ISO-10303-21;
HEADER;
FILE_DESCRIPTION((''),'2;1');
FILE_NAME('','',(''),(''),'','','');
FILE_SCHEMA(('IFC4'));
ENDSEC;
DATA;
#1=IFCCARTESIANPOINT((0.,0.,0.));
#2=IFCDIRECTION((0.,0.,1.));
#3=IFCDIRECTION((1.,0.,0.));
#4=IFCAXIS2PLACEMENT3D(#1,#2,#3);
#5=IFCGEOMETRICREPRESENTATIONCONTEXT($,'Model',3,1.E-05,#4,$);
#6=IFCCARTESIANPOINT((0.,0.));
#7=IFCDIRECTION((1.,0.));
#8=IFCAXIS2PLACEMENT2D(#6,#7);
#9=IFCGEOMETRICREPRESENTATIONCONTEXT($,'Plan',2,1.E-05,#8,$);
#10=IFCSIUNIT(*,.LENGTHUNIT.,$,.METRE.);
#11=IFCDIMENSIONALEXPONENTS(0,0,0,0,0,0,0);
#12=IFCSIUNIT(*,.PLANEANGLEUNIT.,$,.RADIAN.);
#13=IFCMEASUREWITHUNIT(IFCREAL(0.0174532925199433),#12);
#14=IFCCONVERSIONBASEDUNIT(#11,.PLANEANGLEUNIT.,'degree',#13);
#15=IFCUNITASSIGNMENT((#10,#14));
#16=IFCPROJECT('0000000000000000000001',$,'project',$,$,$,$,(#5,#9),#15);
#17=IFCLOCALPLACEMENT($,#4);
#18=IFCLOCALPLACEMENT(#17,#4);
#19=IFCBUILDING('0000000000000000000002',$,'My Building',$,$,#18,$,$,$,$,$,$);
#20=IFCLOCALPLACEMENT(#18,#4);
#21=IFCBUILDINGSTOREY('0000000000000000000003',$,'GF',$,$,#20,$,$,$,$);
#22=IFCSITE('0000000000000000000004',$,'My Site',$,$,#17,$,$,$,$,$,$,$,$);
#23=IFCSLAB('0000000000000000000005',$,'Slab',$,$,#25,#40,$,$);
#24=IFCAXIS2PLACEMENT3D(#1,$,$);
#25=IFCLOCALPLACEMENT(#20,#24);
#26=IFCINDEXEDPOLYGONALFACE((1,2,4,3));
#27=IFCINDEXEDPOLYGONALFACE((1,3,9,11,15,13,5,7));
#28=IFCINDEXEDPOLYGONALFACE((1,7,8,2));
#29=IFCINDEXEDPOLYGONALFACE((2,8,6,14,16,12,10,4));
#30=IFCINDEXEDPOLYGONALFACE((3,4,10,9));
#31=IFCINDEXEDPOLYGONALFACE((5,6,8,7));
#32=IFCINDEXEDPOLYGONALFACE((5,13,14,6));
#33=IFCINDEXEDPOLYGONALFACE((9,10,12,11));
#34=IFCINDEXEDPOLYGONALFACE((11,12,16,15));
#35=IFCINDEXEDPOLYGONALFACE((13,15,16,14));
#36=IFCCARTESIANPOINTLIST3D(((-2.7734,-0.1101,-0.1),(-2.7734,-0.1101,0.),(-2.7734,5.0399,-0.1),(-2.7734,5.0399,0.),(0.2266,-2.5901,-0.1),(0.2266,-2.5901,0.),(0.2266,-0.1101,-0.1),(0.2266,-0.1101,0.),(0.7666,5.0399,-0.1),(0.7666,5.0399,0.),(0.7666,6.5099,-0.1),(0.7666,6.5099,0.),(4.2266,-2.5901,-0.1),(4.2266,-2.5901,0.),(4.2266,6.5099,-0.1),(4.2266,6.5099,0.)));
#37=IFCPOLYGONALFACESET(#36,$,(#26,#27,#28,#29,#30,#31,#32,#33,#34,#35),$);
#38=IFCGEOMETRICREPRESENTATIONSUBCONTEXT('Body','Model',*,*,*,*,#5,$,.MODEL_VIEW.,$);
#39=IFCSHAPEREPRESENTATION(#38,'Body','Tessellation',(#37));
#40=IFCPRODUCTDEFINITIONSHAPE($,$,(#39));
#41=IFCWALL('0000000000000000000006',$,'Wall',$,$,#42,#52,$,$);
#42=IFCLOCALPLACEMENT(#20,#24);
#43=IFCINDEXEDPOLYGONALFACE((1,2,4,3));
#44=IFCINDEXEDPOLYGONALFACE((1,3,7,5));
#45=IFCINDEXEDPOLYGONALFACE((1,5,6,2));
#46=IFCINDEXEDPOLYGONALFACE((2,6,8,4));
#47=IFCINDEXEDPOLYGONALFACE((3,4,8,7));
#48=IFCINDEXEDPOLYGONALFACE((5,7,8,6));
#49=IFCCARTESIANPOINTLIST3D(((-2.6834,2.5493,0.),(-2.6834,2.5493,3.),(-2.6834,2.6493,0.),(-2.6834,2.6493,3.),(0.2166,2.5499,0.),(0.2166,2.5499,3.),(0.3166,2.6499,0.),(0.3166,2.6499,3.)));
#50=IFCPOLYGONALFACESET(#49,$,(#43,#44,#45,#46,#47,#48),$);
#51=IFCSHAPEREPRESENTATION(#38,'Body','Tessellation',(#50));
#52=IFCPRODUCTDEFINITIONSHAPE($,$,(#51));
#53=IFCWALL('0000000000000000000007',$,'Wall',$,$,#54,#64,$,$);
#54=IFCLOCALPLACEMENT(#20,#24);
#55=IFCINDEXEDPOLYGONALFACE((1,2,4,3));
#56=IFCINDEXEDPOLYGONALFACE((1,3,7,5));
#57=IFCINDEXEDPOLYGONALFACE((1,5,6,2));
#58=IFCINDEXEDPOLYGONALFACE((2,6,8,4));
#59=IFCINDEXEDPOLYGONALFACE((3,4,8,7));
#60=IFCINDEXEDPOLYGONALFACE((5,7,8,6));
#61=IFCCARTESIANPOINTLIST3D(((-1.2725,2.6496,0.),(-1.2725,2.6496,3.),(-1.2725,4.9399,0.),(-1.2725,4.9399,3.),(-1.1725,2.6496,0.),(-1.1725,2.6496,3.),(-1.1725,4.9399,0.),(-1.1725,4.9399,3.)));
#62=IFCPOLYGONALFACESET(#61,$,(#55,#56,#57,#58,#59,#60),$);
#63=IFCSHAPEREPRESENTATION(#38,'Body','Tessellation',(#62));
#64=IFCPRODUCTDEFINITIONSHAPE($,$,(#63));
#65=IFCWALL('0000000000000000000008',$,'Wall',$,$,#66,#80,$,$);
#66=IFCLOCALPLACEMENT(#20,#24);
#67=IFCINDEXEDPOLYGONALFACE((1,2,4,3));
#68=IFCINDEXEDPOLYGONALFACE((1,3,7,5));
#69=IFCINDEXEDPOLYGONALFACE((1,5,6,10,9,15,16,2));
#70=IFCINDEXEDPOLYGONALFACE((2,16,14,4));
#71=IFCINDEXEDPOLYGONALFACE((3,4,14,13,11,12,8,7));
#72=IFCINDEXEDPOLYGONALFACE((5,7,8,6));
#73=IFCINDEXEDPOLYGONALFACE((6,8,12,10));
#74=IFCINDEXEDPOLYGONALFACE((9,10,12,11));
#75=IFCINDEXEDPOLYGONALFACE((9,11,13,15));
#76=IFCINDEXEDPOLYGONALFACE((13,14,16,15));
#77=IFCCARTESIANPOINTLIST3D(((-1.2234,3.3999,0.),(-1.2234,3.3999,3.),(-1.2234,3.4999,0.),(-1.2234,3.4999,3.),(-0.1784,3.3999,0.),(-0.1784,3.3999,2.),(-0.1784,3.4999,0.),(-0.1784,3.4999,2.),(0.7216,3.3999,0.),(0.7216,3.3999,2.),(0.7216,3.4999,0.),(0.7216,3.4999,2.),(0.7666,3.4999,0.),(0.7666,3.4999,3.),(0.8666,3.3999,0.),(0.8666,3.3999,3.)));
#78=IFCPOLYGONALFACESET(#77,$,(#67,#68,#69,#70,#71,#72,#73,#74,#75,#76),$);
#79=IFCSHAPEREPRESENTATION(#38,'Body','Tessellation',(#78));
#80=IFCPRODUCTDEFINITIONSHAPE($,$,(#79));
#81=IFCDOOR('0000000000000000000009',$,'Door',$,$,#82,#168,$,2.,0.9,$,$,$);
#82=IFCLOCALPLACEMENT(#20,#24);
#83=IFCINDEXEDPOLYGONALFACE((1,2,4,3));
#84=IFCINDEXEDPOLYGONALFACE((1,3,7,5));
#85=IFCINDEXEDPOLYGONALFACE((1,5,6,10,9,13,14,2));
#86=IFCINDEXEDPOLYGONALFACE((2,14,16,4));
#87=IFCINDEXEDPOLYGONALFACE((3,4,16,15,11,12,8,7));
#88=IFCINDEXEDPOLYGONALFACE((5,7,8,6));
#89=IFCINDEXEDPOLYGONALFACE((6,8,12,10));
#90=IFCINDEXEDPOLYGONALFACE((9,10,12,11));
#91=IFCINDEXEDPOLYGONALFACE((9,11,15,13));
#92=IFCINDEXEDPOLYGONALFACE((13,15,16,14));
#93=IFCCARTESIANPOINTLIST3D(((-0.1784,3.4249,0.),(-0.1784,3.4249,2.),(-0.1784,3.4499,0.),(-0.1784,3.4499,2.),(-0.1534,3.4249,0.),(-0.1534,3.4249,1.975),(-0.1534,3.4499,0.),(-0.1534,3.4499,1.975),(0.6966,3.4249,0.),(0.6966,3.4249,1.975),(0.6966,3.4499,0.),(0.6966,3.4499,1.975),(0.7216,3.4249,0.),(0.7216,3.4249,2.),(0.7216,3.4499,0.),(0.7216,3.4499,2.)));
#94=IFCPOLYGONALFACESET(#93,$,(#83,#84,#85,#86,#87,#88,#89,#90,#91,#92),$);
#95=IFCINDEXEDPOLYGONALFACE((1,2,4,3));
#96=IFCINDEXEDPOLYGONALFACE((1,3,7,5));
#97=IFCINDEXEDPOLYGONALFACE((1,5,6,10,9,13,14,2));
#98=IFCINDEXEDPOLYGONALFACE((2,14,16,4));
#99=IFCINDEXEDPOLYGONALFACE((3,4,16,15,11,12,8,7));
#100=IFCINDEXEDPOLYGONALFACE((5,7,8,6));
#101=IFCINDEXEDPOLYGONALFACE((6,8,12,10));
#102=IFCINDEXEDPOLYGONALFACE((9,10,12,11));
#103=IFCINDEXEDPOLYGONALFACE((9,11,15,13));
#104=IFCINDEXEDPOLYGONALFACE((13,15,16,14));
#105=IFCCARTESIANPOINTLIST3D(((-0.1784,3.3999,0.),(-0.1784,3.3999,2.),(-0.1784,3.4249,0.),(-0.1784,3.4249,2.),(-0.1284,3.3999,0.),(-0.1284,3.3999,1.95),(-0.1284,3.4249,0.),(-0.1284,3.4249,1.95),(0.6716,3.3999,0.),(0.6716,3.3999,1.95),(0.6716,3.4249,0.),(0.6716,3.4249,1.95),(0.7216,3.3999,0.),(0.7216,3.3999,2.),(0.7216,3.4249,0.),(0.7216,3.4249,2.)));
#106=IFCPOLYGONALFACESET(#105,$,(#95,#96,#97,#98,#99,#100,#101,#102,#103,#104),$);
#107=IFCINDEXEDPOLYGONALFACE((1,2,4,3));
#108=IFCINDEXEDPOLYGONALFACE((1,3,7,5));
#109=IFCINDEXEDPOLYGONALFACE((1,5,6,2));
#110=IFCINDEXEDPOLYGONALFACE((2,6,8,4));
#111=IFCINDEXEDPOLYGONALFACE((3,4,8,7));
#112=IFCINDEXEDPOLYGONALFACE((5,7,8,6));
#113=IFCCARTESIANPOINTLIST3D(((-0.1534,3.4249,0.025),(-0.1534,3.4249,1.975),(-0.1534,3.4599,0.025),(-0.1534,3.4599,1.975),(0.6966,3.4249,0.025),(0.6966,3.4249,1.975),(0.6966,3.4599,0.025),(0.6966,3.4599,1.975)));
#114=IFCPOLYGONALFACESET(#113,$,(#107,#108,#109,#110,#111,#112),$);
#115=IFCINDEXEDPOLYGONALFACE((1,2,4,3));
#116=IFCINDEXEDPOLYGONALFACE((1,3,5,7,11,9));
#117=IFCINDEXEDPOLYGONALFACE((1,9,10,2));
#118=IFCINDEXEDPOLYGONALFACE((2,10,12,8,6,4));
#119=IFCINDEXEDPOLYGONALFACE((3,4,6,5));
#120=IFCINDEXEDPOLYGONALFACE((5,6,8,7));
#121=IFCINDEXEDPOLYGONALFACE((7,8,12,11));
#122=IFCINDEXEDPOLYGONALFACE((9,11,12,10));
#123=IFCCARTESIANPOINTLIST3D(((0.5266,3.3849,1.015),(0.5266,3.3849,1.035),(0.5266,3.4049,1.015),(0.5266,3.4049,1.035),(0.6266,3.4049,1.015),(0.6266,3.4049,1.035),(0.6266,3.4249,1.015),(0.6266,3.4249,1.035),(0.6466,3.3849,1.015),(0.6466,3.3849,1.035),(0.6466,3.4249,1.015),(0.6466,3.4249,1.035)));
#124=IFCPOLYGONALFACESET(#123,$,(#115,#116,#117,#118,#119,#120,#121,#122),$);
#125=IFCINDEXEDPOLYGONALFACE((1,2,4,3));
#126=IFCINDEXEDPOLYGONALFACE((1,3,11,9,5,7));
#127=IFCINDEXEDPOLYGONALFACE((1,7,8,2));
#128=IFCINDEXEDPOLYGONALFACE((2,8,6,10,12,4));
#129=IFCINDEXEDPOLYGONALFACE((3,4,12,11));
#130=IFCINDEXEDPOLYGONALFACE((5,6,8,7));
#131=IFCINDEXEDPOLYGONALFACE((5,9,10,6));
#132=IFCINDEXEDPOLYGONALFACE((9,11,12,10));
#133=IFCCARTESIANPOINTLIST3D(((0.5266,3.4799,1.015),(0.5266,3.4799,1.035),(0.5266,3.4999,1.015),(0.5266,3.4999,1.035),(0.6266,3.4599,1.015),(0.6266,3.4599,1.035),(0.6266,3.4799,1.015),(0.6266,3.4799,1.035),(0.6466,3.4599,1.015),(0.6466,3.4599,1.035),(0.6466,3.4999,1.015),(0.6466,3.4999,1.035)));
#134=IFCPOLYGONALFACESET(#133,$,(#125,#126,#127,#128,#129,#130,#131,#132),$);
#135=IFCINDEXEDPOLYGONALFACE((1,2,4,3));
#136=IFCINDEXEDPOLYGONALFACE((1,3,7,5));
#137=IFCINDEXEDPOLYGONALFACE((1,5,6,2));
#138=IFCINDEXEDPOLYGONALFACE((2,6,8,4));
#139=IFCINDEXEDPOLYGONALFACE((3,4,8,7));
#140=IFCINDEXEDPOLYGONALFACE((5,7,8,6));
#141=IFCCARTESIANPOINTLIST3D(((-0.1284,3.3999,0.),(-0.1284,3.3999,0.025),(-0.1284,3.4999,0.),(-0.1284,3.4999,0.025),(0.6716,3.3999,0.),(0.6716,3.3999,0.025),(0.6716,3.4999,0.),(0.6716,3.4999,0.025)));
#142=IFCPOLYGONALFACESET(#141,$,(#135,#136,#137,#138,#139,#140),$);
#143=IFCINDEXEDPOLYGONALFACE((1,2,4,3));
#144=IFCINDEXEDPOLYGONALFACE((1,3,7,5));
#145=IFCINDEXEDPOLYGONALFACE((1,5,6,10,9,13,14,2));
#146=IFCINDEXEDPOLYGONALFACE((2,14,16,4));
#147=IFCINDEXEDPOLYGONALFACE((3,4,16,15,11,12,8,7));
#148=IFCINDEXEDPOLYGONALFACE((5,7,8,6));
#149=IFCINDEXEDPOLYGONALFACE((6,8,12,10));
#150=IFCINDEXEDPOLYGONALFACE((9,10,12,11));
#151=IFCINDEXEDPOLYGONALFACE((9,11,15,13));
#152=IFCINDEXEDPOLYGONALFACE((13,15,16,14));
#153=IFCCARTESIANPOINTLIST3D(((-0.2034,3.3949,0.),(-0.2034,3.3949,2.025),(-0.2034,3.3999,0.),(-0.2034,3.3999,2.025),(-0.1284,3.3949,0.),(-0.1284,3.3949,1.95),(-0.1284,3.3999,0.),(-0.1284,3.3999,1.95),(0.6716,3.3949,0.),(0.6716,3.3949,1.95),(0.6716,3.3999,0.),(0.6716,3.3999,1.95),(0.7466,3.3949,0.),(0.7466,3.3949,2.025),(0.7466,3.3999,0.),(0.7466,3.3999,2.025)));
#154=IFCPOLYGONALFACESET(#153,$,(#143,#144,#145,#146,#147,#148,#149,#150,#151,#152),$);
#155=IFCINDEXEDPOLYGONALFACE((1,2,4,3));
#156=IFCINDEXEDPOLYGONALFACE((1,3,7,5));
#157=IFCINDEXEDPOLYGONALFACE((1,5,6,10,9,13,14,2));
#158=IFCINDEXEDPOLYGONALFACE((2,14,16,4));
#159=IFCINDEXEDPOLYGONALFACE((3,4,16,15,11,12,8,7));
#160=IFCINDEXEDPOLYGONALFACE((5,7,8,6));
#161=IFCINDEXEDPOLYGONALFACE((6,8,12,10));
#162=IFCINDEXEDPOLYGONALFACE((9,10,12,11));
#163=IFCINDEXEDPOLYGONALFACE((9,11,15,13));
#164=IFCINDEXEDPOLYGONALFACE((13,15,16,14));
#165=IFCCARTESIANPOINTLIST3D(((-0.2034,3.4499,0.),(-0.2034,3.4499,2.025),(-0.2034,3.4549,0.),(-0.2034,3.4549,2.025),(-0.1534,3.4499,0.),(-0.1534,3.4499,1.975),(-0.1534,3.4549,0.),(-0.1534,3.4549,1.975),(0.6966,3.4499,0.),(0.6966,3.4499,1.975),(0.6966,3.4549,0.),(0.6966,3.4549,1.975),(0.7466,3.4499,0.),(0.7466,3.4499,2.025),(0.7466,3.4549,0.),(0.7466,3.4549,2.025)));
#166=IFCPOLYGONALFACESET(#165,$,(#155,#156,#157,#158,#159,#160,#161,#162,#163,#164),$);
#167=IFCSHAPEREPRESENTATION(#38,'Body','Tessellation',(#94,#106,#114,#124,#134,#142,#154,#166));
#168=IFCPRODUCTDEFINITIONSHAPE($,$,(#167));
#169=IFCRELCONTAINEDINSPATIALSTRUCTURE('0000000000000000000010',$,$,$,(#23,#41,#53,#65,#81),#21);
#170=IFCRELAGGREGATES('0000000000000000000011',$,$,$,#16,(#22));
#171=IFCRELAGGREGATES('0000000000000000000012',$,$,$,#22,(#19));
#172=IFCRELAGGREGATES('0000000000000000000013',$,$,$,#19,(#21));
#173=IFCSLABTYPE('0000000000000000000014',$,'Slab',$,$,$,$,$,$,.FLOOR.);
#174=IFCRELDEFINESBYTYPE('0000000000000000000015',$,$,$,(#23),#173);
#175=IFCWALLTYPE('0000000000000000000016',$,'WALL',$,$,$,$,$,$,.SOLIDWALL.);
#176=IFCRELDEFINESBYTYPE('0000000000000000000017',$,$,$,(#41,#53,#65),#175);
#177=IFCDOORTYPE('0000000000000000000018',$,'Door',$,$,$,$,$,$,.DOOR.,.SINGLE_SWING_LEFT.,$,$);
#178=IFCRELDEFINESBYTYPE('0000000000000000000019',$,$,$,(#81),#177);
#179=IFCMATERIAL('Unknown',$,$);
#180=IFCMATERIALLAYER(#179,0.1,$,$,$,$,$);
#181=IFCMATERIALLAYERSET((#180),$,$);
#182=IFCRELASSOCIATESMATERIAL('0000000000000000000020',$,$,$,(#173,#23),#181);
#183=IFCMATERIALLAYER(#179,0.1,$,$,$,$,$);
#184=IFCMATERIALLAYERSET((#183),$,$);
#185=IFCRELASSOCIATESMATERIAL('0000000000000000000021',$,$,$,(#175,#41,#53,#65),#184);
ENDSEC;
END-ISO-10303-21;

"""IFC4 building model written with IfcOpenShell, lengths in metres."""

from ifc_helpers import new_model, entity, si_unit, converted_unit, frame, origin_with_axes, origin_2d_with_axis, place, context, subcontext, project, spatial, line, indexed_curve, outline, extrude, shape, source, transform, mapped, material, layer, layer_set, layer_usage, type_object, type_shapes, element, fill, save


model = new_model("IFC4")

# Units and contexts
model_context = context("Model", 3, precision=1e-05, world=origin_with_axes())
plan_context = context("Plan", 2, precision=1e-05, world=origin_2d_with_axis())
body_context_1 = subcontext(model_context, "Body", "Model", "MODEL_VIEW")
body_context_2 = subcontext(plan_context, "Body", "Plan", "PLAN_VIEW")
ifc_project = project(units=[si_unit("LENGTHUNIT", "METRE"), converted_unit("PLANEANGLEUNIT", "degree", entity("IfcReal", 0.0174532925199433), si_unit("PLANEANGLEUNIT", "RADIAN"), dimensions=[0, 0, 0, 0, 0, 0, 0])], contexts=[model_context, plan_context])

# Site, building, storey
site_placement = place(None, origin_with_axes())
site = spatial("IfcSite", under=ifc_project, at=site_placement, Name="My Site")
building_placement = place(site_placement, origin_with_axes())
building = spatial("IfcBuilding", under=site, at=building_placement, Name="My Building")
storey_placement = place(building_placement, origin_with_axes())
storey = spatial("IfcBuildingStorey", under=building, at=storey_placement, Name="GF")

# Slab
ifc_material = material(Name="Unknown")
ifc_layer_1 = layer(ifc_material, 0.1)
ifc_layer_set_1 = layer_set([ifc_layer_1])
ifc_layer_usage_1 = layer_usage(ifc_layer_set_1, "AXIS3", "POSITIVE", -0.1)
slab_type = type_object("IfcSlabType", Name="Slab", PredefinedType="FLOOR", material=ifc_layer_set_1)
slab_placement = place(storey_placement, frame((4.2266, -2.5901, 0.0), z_axis=(0.0, 0.0, 1.0), x_axis=(1.0, 0.0, 0.0)))
element("IfcSlab", 1, at=slab_placement, inside=storey, type_object=slab_type, material=ifc_layer_usage_1, Name="Slab", context=body_context_1, shape_type="SweptSolid", body=[
    extrude(outline(indexed_curve([(0.0, 0.0), (0.0, 9.1), (-3.46, 9.1), (-3.46, 7.63), (-7.0, 7.63), (-7.0, 2.48), (-4.0, 2.48), (-4.0, 0.0), (0.0, 0.0)])), frame((0.0, 0.0, -0.1), z_axis=(0.0, 0.0, 1.0), x_axis=(1.0, 0.0, 0.0)), (0.0, 0.0, 1.0), 0.1),
])

# Walls
ifc_layer_2 = layer(ifc_material, 0.1)
ifc_layer_set_2 = layer_set([ifc_layer_2])
ifc_layer_usage_2 = layer_usage(ifc_layer_set_2, "AXIS2", "POSITIVE", 0.0)
wall_type_1 = type_object("IfcWallType", Name="WALL", PredefinedType="SOLIDWALL", material=ifc_layer_set_2)
wall_1_placement = place(storey_placement, frame((0.3166, 2.6499, 0.0), z_axis=(0.0, 0.0, 1.0), x_axis=(-1.0, -0.0002, 0.0)))
element("IfcWall", 2, at=wall_1_placement, inside=storey, type_object=wall_type_1, material=ifc_layer_usage_2, Name="Wall", context=body_context_1, shape_type="SweptSolid", body=[
    extrude(outline(indexed_curve([(0.0, 0.0), (0.1, 0.1), (3.0, 0.1), (3.0, 0.0)], segments=[line(1, 2, 3, 4, 1)])), origin_with_axes(), (0.0, 0.0, 1.0), 3.0),
])
ifc_layer_usage_3 = layer_usage(ifc_layer_set_2, "AXIS2", "POSITIVE", 0.0)
wall_2_placement = place(storey_placement, frame((-1.2725, 4.9399, 0.0), z_axis=(0.0, 0.0, 1.0), x_axis=(0.000001, -1.0, 0.0)))
element("IfcWall", 3, at=wall_2_placement, inside=storey, type_object=wall_type_1, material=ifc_layer_usage_3, Name="Wall", context=body_context_1, shape_type="SweptSolid", body=[
    extrude(outline(indexed_curve([(0.0, 0.0), (0.0, 0.1), (2.2903, 0.1), (2.2903, 0.0)], segments=[line(1, 2, 3, 4, 1)])), origin_with_axes(), (0.0, 0.0, 1.0), 3.0),
])

# Wall, opening, door
ifc_layer_usage_4 = layer_usage(ifc_layer_set_2, "AXIS2", "POSITIVE", 0.0)
wall_3_placement = place(storey_placement, frame((-1.2234, 3.3999, 0.0), z_axis=(0.0, 0.0, 1.0), x_axis=(1.0, 0.0, 0.0)))
wall_3 = element("IfcWall", 4, at=wall_3_placement, inside=storey, type_object=wall_type_1, material=ifc_layer_usage_4, Name="Wall", context=body_context_1, shape_type="SweptSolid", body=[
    extrude(outline(indexed_curve([(0.0, 0.0), (0.0, 0.1), (1.99, 0.1), (2.09, 0.0)], segments=[line(1, 2, 3, 4, 1)])), origin_with_axes(), (0.0, 0.0, 1.0), 3.0),
])
shared_shape_1 = source(origin_with_axes(), body_context_1, "Body", "SweptSolid", [
    extrude(outline(indexed_curve([(0.0, 0.0), (0.9, 0.0), (0.9, 2.0), (0.0, 2.0)], segments=[line(1, 2, 3, 4, 1)])), frame((0.0, -0.6, 0.0), z_axis=(0.0, -1.0, 0.0), x_axis=(1.0, 0.0, 0.0)), (0.0, 0.0, -1.0), 1.2),
])
opening_1_placement = place(wall_3_placement, frame((1.045, 0.0, 0.0), z_axis=(0.0, 0.0, 1.0), x_axis=(1.0, 0.0, 0.0)))
opening_1 = element("IfcOpeningElement", 5, at=opening_1_placement, cuts=wall_3, PredefinedType="OPENING", context=body_context_1, shape_type="MappedRepresentation", body=[
    mapped(shared_shape_1, transform((0.0, 0.0, 0.0), x_axis=(1.0, 0.0, 0.0), y_axis=(0.0, 1.0, 0.0), z_axis=(0.0, 0.0, 1.0), scale=1.0)),
])
door_type = type_object("IfcDoorType", Name="Door", OperationType="SINGLE_SWING_LEFT", PredefinedType="DOOR")
shared_shape_2 = source(origin_with_axes(), body_context_1, "Body", "SweptSolid", [
    extrude(outline(indexed_curve([(0.0, 0.0), (0.0, 2.0), (0.9, 2.0), (0.9, 0.0), (0.875, 0.0), (0.875, 1.975), (0.025, 1.975), (0.025, 0.0)], segments=[line(1, 2, 3, 4, 5, 6, 7, 8, 1)])), frame((0.0, 0.025, 0.0), z_axis=(0.0, -1.0, 0.0), x_axis=(1.0, 0.0, 0.0)), (0.0, 0.0, -1.0), 0.025),
    extrude(outline(indexed_curve([(0.0, 0.0), (0.0, 2.0), (0.9, 2.0), (0.9, 0.0), (0.85, 0.0), (0.85, 1.95), (0.05, 1.95), (0.05, 0.0)], segments=[line(1, 2, 3, 4, 5, 6, 7, 8, 1)])), frame((0.0, 0.0, 0.0), z_axis=(0.0, -1.0, 0.0), x_axis=(1.0, 0.0, 0.0)), (0.0, 0.0, -1.0), 0.025),
    extrude(outline(indexed_curve([(0.0, 0.0), (0.85, 0.0), (0.85, 0.035), (0.0, 0.035)], segments=[line(1, 2, 3, 4, 1)])), frame((0.025, 0.025, 0.025), z_axis=(0.0, 0.0, 1.0), x_axis=(1.0, 0.0, 0.0)), (0.0, 0.0, 1.0), 1.95),
    extrude(outline(indexed_curve([(0.0, 0.0), (0.0, -0.04), (-0.12, -0.04), (-0.12, -0.02), (-0.02, -0.02), (-0.02, 0.0)], segments=[line(1, 2, 3, 4, 5, 6, 1)])), frame((0.825, 0.025, 1.015), z_axis=(0.0, 0.0, 1.0), x_axis=(1.0, 0.0, 0.0)), (0.0, 0.0, 1.0), 0.02),
    extrude(outline(indexed_curve([(0.0, 0.0), (0.0, 0.04), (-0.12, 0.04), (-0.12, 0.02), (-0.02, 0.02), (-0.02, 0.0)], segments=[line(1, 2, 3, 4, 5, 6, 1)])), frame((0.825, 0.06, 1.015), z_axis=(0.0, 0.0, 1.0), x_axis=(1.0, 0.0, 0.0)), (0.0, 0.0, 1.0), 0.02),
    extrude(outline(indexed_curve([(0.0, 0.0), (0.8, 0.0), (0.8, 0.1), (0.0, 0.1)], segments=[line(1, 2, 3, 4, 1)])), frame((0.05, 0.0, 0.0), z_axis=(0.0, 0.0, 1.0), x_axis=(1.0, 0.0, 0.0)), (0.0, 0.0, 1.0), 0.025),
    extrude(outline(indexed_curve([(0.0, 0.0), (0.0, 2.025), (0.95, 2.025), (0.95, 0.0), (0.875, 0.0), (0.875, 1.95), (0.075, 1.95), (0.075, 0.0)], segments=[line(1, 2, 3, 4, 5, 6, 7, 8, 1)])), frame((-0.025, -0.005, 0.0), z_axis=(0.0, -1.0, 0.0), x_axis=(1.0, 0.0, 0.0)), (0.0, 0.0, -1.0), 0.005),
    extrude(outline(indexed_curve([(0.0, 0.0), (0.0, 2.025), (0.95, 2.025), (0.95, 0.0), (0.9, 0.0), (0.9, 1.975), (0.05, 1.975), (0.05, 0.0)], segments=[line(1, 2, 3, 4, 5, 6, 7, 8, 1)])), frame((-0.025, 0.05, 0.0), z_axis=(0.0, -1.0, 0.0), x_axis=(1.0, 0.0, 0.0)), (0.0, 0.0, -1.0), 0.005),
])
shared_shape_3 = source(origin_with_axes(), body_context_2, "Body", "Curve2D", [
    entity("IfcIndexedPolyCurve", entity("IfcCartesianPointList2D", [[0.0, 0.0], [0.0, 0.05], [0.025, 0.05], [0.025, 0.025], [0.05, 0.025], [0.05, 0.0]]), [entity("IfcLineIndex", [1, 2, 3, 4, 5, 6, 1])]),
    entity("IfcIndexedPolyCurve", entity("IfcCartesianPointList2D", [[0.9, 0.0], [0.9, 0.05], [0.875, 0.05], [0.875, 0.025], [0.85, 0.025], [0.85, 0.0]]), [entity("IfcLineIndex", [1, 2, 3, 4, 5, 6, 1])]),
    entity("IfcTrimmedCurve", entity("IfcEllipse", entity("IfcAxis2Placement2D", entity("IfcCartesianPoint", [0.06, 0.05]), entity("IfcDirection", [1.0, 0.0])), 0.815, 0.85), [entity("IfcCartesianPoint", [0.875, 0.05])], [entity("IfcCartesianPoint", [0.06, 0.9])], True, "CARTESIAN"),
    entity("IfcIndexedPolyCurve", entity("IfcCartesianPointList2D", [[0.025, 0.05], [0.06, 0.05], [0.06, 0.9], [0.025, 0.9]]), [entity("IfcLineIndex", [1, 2, 3, 4, 1])]),
])
type_shapes(door_type, [shared_shape_2, shared_shape_3])
door_1_placement = place(opening_1_placement, origin_with_axes())
door_1 = element("IfcDoor", 6, at=door_1_placement, inside=storey, type_object=door_type, Name="Door", OverallHeight=2.0, OverallWidth=0.9, shapes=[
    shape(body_context_1, "Body", "MappedRepresentation", [mapped(shared_shape_2, transform((0.0, 0.0, 0.0), x_axis=(1.0, 0.0, 0.0), y_axis=(0.0, 1.0, 0.0), z_axis=(0.0, 0.0, 1.0), scale=1.0))]),
    shape(body_context_2, "Body", "MappedRepresentation", [mapped(shared_shape_3, transform((0.0, 0.0, 0.0), x_axis=(1.0, 0.0, 0.0), y_axis=(0.0, 1.0, 0.0), z_axis=(0.0, 0.0, 1.0), scale=1.0))]),
])
fill(opening_1, door_1)

save(model, "model.ifc")
